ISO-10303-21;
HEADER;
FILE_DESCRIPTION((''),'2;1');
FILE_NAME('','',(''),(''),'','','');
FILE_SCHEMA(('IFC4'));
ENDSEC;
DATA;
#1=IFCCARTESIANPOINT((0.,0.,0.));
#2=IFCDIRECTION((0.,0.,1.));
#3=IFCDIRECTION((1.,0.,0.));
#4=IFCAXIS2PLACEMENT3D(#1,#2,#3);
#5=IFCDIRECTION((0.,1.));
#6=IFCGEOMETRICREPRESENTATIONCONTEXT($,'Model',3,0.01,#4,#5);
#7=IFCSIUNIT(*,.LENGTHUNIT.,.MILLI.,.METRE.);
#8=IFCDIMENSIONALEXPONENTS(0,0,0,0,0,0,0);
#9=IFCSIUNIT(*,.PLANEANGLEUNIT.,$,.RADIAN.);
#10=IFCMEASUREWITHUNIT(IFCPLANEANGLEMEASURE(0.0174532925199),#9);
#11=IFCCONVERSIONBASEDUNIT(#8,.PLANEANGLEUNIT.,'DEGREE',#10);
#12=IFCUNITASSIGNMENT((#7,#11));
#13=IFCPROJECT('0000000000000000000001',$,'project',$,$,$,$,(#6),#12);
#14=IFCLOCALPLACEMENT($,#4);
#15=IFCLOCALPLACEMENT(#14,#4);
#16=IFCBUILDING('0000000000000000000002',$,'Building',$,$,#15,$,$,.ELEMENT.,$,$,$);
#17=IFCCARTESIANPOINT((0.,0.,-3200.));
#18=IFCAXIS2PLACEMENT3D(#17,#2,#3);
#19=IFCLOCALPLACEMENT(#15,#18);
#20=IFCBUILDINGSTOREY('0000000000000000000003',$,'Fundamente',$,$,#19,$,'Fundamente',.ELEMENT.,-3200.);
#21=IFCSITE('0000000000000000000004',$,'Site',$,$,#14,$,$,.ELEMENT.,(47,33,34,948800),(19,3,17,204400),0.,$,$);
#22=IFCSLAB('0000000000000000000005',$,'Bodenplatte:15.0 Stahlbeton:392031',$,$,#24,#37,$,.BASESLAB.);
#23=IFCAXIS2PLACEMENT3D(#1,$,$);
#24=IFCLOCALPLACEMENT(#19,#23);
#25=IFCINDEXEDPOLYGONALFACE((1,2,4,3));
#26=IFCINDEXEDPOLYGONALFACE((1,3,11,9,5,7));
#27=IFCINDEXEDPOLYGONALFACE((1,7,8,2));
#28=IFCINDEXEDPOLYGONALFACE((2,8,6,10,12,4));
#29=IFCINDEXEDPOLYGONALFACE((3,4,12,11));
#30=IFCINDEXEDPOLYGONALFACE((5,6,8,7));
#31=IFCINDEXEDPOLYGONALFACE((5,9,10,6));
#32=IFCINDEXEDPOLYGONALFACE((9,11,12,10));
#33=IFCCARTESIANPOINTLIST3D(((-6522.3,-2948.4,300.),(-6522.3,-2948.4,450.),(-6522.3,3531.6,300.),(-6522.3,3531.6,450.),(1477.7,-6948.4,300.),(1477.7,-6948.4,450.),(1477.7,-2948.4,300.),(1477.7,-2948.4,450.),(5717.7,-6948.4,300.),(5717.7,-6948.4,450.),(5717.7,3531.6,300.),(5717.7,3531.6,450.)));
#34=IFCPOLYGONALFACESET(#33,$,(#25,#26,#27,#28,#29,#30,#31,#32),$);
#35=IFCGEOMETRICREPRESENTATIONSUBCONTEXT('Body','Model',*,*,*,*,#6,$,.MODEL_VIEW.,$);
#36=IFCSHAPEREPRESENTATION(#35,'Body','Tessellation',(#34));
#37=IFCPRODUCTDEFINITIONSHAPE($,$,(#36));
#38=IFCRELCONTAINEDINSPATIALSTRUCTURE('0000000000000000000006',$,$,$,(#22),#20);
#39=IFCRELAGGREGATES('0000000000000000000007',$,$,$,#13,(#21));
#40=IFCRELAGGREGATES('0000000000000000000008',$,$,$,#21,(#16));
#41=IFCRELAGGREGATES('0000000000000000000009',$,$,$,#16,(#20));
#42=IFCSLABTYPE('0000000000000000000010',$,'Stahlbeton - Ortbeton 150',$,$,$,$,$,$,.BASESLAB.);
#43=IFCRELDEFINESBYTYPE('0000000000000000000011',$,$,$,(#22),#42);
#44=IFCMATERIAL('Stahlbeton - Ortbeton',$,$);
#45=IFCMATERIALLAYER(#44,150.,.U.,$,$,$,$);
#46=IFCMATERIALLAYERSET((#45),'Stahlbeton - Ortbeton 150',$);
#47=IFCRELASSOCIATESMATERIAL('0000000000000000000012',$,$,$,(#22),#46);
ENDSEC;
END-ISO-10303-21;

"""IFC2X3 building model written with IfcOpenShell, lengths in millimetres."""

from ifc_helpers import new_model, entity, si_unit, converted_unit, direction, frame, origin_with_axes, place, context, subcontext, project, spatial, polyline, outline, extrude, material, layer, layer_set, layer_usage, type_object, element, save


model = new_model("IFC2X3")

# Units and contexts
model_context = context("Model", 3, precision=0.01, world=origin_with_axes(), true_north=direction((0.0, 1.0)))
body_context = subcontext(model_context, "Body", "Model", "MODEL_VIEW")
ifc_project = project(units=[si_unit("LENGTHUNIT", "METRE", prefix="MILLI"), converted_unit("PLANEANGLEUNIT", "DEGREE", entity("IfcPlaneAngleMeasure", 0.0174532925199), si_unit("PLANEANGLEUNIT", "RADIAN"), dimensions=[0, 0, 0, 0, 0, 0, 0])], contexts=[model_context])

# Site, building, storey
site_placement = place(None, origin_with_axes())
site = spatial("IfcSite", under=ifc_project, at=site_placement, Name="Site", CompositionType="ELEMENT", RefLatitude=(47, 33, 34, 948800), RefLongitude=(19, 3, 17, 204400), RefElevation=0.0)
building_placement = place(site_placement, origin_with_axes())
building = spatial("IfcBuilding", under=site, at=building_placement, Name="Building", CompositionType="ELEMENT")
storey_placement = place(building_placement, frame((0.0, 0.0, -3200.0), z_axis=(0.0, 0.0, 1.0), x_axis=(1.0, 0.0, 0.0)))
storey = spatial("IfcBuildingStorey", under=building, at=storey_placement, Name="Fundamente", LongName="Fundamente", CompositionType="ELEMENT", Elevation=-3200.0)

# Shared definitions
ifc_material = material(Name="Stahlbeton - Ortbeton")

# Slab
ifc_layer = layer(ifc_material, 150.0, ventilated="UNKNOWN")
ifc_layer_set = layer_set([ifc_layer], Name="Stahlbeton - Ortbeton 150")
ifc_layer_usage = layer_usage(ifc_layer_set, "AXIS3", "NEGATIVE", 150.0)
slab_type = type_object("IfcSlabType", Name="Stahlbeton - Ortbeton 150", PredefinedType="BASESLAB")
slab_placement = place(storey_placement, frame((-6522.3, -2948.4, 450.0), z_axis=(0.0, 0.0, 1.0), x_axis=(1.0, 0.0, 0.0)))
element("IfcSlab", 1, at=slab_placement, inside=storey, type_object=slab_type, material=ifc_layer_usage, Name="Bodenplatte:15.0 Stahlbeton:392031", PredefinedType="BASESLAB", context=body_context, shape_type="SweptSolid", body=[
    extrude(outline(polyline([(0.0, 0.0), (8000.0, 0.0), (8000.0, -4000.0), (12240.0, -4000.0), (12240.0, 6480.0), (0.0, 6480.0), (0.0, 0.0)])), frame((0.0, 0.0, -150.0), z_axis=(0.0, 0.0, 1.0), x_axis=(1.0, 0.0, 0.0)), (0.0, 0.0, 1.0), 150.0),
])

save(model, "model.ifc")
